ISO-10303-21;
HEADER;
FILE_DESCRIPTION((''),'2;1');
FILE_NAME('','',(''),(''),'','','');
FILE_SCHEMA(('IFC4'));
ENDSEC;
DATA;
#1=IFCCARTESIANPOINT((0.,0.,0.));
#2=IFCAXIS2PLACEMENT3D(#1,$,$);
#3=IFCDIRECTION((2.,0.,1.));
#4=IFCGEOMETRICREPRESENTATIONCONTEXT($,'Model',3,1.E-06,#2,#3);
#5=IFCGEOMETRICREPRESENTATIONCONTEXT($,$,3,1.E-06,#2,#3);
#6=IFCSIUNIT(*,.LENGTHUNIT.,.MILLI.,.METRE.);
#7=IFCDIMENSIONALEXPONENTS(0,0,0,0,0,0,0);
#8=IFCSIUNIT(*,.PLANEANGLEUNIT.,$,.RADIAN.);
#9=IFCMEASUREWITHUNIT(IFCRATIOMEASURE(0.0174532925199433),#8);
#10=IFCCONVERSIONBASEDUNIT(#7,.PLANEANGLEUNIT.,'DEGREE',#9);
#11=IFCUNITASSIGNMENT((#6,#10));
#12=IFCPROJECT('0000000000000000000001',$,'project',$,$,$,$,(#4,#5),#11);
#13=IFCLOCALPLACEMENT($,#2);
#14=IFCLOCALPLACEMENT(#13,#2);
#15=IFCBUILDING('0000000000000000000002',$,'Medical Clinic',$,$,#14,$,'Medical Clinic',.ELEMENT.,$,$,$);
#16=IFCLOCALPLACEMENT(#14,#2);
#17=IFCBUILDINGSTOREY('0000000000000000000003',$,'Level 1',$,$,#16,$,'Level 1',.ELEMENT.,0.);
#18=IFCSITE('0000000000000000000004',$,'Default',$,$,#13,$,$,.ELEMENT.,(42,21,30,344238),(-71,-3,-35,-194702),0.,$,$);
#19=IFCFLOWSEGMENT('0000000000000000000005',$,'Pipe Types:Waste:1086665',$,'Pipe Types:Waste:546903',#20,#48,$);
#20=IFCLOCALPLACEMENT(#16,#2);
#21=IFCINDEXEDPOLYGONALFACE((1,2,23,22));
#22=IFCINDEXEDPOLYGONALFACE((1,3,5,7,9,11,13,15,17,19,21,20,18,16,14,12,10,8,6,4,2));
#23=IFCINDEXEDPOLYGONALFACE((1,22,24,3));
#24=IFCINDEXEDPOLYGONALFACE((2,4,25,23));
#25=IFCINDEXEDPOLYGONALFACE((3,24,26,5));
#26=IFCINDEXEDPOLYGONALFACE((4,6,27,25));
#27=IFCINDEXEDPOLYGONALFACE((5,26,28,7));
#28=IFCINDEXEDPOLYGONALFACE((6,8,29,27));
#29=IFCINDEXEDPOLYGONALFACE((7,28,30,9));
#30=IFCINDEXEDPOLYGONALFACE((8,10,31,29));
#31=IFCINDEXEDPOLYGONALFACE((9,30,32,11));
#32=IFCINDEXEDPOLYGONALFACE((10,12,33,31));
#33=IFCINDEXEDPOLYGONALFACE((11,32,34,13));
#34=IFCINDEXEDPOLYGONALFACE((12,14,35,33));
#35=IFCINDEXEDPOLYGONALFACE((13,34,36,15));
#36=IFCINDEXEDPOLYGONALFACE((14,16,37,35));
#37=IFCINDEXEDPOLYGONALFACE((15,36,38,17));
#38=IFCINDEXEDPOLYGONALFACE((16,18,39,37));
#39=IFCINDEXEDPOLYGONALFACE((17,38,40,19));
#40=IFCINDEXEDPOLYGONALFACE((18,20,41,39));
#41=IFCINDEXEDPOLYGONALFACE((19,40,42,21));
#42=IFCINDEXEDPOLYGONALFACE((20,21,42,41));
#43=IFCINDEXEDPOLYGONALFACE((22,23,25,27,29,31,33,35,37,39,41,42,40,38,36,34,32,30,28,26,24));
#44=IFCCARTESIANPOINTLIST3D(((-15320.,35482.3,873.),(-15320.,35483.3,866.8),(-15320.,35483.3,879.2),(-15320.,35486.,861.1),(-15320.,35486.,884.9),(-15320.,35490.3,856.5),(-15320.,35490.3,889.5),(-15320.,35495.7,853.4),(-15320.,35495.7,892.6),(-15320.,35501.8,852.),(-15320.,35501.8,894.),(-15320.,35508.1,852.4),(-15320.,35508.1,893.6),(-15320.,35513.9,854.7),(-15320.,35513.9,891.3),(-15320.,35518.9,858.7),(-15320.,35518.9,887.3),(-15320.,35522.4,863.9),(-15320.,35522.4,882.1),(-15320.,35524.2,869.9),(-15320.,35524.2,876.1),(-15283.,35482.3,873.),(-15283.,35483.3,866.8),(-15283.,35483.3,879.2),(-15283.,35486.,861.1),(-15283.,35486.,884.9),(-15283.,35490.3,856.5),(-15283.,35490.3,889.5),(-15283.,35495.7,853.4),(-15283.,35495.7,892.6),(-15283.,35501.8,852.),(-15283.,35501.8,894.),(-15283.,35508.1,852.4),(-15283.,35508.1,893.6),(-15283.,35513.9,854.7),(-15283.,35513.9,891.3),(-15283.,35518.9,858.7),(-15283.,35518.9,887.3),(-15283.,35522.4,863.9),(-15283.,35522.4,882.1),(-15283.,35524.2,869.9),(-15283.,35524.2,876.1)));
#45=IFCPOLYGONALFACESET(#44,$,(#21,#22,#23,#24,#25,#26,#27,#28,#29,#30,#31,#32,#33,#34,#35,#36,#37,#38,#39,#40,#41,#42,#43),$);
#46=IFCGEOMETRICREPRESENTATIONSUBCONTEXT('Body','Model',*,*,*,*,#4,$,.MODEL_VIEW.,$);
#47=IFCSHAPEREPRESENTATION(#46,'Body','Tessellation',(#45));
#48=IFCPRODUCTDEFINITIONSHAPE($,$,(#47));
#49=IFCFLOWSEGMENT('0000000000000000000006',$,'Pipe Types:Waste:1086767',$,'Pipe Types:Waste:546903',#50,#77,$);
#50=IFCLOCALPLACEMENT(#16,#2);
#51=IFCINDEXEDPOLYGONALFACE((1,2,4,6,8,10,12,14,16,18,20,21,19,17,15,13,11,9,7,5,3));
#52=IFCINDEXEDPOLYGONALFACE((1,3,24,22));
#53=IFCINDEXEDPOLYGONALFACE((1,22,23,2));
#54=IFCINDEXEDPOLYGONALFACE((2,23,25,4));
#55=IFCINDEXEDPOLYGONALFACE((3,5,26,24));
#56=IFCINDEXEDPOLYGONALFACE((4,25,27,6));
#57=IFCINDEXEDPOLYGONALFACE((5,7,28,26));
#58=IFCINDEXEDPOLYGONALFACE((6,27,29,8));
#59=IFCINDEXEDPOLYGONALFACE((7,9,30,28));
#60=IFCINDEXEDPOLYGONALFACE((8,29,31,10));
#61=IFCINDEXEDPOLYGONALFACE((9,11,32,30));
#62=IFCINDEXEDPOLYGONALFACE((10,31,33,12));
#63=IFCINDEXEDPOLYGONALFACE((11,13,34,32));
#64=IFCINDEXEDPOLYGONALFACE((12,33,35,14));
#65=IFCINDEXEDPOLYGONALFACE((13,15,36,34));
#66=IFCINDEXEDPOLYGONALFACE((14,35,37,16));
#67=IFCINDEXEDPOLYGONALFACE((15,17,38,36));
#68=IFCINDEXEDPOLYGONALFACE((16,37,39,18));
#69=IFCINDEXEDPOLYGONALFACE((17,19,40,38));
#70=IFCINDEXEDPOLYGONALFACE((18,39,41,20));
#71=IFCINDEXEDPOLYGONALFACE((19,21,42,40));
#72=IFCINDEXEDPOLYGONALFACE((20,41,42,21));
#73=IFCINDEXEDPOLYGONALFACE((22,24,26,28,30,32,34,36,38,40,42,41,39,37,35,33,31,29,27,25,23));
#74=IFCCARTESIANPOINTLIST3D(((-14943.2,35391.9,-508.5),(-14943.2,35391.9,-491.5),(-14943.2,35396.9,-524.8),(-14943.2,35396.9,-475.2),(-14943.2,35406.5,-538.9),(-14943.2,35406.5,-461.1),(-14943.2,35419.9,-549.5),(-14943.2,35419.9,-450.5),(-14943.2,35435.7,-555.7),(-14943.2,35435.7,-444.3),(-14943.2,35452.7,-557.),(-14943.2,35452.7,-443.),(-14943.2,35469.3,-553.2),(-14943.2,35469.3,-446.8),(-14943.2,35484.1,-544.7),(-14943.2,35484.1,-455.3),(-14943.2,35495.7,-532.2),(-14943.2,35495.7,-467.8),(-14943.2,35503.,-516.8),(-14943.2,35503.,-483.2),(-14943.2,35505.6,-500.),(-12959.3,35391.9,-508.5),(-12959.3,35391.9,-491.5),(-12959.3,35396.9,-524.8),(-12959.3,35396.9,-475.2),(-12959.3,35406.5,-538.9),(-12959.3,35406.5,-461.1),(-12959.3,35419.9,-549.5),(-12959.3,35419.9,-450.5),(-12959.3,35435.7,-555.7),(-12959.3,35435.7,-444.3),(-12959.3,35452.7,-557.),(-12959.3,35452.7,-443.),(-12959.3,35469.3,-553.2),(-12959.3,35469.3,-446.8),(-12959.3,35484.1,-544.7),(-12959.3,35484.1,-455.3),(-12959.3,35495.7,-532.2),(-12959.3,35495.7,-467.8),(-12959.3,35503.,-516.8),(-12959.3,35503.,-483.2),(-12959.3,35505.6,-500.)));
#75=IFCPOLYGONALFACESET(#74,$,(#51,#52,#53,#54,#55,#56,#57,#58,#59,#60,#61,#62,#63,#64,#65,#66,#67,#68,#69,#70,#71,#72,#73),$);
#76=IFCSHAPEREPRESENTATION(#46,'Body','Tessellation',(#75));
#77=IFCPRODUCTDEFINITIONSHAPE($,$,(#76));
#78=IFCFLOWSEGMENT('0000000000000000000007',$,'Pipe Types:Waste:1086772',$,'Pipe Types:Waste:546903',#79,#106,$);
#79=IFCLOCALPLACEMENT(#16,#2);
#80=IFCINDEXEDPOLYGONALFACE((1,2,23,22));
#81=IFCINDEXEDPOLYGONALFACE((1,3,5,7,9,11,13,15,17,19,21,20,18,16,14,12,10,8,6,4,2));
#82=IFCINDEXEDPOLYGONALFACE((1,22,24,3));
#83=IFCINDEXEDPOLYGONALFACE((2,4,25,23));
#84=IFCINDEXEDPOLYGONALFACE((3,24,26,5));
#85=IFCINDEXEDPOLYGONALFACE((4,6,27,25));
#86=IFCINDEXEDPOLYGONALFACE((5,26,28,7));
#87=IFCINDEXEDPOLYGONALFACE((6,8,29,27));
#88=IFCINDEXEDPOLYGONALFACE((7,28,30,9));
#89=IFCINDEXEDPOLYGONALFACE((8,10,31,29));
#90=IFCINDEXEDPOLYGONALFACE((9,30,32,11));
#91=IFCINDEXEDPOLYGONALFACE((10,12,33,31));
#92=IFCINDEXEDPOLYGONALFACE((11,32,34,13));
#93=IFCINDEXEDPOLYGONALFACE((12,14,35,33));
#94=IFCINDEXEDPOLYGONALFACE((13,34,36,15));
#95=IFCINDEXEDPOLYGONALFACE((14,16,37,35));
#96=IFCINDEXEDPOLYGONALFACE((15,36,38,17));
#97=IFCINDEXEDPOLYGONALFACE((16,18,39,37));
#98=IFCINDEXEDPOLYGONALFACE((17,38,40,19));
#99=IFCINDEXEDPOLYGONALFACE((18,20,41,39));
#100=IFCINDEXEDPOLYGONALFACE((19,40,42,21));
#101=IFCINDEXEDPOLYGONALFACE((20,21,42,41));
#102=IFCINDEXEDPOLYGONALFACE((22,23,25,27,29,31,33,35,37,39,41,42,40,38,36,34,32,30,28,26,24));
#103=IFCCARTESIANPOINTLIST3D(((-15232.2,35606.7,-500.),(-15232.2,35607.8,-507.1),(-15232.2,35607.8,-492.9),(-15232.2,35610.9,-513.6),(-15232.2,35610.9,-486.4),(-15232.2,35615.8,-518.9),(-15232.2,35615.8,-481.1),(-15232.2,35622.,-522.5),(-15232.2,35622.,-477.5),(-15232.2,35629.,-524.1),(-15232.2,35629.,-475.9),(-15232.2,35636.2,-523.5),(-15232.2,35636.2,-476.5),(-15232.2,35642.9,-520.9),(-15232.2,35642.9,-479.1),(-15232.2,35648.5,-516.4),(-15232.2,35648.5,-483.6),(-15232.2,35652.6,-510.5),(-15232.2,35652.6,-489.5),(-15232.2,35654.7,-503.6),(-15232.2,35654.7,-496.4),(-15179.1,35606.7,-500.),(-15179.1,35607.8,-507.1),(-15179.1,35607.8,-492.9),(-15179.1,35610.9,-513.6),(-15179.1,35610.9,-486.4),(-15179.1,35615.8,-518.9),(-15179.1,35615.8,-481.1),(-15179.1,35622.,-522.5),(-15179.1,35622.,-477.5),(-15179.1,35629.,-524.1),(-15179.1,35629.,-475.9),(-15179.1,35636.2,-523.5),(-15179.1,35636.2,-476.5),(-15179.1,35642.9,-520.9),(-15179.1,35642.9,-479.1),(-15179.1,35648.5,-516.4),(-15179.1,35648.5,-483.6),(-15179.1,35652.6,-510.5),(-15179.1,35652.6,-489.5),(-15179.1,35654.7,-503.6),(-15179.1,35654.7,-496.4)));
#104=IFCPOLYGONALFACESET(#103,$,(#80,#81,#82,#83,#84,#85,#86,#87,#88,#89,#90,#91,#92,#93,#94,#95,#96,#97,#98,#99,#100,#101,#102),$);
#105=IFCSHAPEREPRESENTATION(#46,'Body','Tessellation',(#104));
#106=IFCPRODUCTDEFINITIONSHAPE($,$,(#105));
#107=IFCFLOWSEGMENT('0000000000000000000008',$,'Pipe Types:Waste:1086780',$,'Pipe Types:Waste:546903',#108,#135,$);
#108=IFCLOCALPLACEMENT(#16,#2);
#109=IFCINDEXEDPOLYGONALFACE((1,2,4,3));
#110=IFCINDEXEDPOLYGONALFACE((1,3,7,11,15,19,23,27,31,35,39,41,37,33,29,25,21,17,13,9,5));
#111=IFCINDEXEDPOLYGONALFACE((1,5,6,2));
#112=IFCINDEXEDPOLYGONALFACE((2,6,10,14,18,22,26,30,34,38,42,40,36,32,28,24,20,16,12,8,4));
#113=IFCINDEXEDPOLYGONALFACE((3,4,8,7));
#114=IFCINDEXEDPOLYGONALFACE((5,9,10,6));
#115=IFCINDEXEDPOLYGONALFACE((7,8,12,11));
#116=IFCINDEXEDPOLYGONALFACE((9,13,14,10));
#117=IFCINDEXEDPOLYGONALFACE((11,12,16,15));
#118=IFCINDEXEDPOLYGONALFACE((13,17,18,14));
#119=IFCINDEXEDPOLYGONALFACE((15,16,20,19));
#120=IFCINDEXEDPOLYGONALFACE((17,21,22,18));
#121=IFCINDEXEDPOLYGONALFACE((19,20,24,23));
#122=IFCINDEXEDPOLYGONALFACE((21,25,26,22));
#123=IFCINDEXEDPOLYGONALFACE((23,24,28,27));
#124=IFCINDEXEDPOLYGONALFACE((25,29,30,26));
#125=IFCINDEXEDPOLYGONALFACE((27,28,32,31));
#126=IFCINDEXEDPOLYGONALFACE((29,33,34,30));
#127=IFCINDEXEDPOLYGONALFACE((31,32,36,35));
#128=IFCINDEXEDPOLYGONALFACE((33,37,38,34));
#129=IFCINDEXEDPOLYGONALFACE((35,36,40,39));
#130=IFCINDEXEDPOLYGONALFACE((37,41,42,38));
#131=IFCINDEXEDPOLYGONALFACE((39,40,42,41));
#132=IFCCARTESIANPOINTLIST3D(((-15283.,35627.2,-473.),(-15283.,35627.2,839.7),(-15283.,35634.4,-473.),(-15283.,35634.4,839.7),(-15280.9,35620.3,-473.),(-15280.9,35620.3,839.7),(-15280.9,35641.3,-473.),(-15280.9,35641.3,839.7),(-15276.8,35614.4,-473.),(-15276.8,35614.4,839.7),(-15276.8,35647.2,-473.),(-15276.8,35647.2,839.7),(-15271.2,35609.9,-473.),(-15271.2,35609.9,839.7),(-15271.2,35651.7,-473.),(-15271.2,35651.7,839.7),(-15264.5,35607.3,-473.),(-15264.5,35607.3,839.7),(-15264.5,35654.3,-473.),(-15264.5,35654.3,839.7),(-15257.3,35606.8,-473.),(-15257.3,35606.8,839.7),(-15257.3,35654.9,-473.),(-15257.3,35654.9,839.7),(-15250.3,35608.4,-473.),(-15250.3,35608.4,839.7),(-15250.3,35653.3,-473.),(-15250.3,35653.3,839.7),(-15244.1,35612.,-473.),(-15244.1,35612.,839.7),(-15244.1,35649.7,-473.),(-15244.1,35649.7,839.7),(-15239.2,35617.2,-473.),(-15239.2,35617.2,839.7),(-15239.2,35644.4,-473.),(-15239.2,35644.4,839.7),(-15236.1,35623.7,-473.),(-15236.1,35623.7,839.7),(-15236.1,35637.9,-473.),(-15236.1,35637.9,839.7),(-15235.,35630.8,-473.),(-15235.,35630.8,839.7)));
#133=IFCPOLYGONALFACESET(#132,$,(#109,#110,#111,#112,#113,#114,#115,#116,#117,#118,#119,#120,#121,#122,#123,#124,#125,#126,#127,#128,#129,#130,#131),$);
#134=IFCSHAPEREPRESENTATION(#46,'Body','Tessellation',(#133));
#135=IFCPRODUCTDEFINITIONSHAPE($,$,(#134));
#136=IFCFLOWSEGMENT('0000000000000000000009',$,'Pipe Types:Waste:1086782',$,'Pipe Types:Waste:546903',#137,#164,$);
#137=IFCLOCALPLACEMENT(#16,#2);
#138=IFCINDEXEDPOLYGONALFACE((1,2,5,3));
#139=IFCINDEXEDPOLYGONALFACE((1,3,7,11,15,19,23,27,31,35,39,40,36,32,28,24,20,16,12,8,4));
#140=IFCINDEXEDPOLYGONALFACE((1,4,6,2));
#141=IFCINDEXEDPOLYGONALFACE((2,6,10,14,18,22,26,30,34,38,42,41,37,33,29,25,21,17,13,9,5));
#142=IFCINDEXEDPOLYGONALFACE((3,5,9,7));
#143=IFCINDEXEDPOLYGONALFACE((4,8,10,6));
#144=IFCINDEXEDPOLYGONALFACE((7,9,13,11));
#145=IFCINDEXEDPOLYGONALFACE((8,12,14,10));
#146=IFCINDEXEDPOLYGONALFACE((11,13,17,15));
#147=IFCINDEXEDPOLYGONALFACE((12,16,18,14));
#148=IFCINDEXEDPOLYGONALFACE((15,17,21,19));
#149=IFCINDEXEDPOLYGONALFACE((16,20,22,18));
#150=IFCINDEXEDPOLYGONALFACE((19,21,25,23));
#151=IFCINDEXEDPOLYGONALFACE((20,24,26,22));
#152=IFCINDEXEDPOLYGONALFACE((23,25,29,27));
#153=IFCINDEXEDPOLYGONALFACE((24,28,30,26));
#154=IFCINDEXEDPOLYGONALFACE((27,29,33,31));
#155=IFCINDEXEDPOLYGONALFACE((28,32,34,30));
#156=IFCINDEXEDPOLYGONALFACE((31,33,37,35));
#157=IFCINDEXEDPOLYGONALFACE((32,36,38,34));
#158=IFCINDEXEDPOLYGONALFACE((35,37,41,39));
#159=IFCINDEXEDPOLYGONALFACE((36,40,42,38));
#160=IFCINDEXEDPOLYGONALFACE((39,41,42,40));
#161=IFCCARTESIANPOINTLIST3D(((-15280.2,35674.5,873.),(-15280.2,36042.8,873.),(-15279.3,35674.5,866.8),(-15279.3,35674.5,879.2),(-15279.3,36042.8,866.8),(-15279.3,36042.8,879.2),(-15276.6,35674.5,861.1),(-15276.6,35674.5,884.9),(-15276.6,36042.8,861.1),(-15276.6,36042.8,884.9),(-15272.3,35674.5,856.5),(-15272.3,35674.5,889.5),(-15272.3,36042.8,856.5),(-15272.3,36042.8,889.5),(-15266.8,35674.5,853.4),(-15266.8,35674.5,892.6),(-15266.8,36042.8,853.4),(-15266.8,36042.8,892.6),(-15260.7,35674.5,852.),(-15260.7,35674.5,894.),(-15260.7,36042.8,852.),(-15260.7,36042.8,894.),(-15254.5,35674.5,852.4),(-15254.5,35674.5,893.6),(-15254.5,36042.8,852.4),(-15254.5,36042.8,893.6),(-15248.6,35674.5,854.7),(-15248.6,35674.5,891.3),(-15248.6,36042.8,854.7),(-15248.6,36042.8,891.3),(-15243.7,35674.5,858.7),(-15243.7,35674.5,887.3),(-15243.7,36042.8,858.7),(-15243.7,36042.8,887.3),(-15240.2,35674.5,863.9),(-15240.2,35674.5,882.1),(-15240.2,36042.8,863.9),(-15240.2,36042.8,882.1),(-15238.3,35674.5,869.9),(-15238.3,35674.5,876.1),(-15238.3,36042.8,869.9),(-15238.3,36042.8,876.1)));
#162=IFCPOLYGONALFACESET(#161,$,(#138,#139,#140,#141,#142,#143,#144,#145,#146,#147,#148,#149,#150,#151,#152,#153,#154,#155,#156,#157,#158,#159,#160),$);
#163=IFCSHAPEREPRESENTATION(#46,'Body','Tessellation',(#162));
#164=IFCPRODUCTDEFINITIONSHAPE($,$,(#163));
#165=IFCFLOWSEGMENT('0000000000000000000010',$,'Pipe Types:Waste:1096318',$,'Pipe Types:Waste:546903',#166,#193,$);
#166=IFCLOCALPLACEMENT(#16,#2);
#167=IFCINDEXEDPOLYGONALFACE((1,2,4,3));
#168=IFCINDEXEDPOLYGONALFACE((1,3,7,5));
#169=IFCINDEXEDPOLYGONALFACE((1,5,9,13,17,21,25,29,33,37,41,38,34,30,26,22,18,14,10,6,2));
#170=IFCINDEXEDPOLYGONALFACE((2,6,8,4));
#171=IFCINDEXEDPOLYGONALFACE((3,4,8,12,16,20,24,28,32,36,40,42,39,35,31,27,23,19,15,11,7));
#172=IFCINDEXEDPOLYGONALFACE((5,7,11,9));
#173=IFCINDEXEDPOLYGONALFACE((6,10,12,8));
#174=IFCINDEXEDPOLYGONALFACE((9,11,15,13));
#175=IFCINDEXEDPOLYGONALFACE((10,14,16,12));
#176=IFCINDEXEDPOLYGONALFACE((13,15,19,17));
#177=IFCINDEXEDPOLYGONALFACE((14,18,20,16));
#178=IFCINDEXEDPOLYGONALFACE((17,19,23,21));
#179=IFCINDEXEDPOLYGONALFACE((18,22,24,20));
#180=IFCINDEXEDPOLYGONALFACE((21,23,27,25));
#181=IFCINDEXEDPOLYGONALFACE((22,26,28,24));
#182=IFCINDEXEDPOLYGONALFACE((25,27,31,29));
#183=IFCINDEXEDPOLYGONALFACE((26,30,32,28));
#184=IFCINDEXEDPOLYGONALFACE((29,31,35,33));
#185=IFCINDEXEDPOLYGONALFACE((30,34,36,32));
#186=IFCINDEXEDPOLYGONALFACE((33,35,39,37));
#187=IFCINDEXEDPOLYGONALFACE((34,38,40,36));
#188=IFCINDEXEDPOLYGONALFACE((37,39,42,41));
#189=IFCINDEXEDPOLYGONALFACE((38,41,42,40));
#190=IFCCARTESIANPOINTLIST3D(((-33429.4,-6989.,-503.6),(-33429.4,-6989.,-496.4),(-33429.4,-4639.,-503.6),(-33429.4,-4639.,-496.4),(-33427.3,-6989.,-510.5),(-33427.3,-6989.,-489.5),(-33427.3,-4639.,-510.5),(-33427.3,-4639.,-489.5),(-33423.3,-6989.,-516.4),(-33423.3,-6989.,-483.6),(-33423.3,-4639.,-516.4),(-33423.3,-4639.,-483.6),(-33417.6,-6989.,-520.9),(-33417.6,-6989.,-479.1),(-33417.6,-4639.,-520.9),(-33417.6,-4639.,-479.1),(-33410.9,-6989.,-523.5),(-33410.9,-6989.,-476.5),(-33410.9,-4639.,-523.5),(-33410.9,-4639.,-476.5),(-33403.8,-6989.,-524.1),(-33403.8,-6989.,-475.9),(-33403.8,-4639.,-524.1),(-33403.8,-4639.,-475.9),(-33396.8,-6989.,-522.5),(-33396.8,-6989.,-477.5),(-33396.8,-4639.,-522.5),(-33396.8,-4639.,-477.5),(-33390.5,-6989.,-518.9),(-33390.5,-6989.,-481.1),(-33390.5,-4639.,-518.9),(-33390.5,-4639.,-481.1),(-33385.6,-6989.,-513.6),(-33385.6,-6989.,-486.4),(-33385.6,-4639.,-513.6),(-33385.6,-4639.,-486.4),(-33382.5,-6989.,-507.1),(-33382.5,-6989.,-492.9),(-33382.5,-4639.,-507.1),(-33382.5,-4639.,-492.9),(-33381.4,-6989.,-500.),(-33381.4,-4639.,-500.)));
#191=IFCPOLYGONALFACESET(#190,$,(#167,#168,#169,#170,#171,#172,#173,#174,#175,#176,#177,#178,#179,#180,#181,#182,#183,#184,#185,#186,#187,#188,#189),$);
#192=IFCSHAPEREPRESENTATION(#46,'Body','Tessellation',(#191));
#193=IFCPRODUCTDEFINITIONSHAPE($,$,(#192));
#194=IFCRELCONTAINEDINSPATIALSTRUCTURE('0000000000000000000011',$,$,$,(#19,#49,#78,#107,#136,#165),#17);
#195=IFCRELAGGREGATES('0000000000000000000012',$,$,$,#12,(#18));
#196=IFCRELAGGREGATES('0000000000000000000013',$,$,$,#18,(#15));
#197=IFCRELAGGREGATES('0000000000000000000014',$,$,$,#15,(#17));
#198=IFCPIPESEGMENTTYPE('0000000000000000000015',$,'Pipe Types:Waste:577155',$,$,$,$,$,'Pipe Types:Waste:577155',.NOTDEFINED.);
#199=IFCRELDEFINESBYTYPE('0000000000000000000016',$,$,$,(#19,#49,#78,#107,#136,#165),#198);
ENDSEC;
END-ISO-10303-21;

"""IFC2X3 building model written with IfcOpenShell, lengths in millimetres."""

from ifc_helpers import new_model, entity, si_unit, converted_unit, direction, frame, frame_2d, origin, origin_2d_with_axis, place, context, subcontext, project, spatial, circle, extrude, type_object, element, save


model = new_model("IFC2X3")

# Units and contexts
model_context = context("Model", 3, precision=1e-06, world=origin(), true_north=direction((2.0, 0.0, 1.0)))
context_of_model = context(None, 3, precision=1e-06, world=origin(), true_north=direction((2.0, 0.0, 1.0)))
body_context = subcontext(model_context, "Body", "Model", "MODEL_VIEW")
ifc_project = project(units=[si_unit("LENGTHUNIT", "METRE", prefix="MILLI"), converted_unit("PLANEANGLEUNIT", "DEGREE", entity("IfcRatioMeasure", 0.0174532925199433), si_unit("PLANEANGLEUNIT", "RADIAN"), dimensions=[0, 0, 0, 0, 0, 0, 0])], contexts=[model_context, context_of_model])

# Site, building, storey
site_placement = place(None, origin())
site = spatial("IfcSite", under=ifc_project, at=site_placement, Name="Default", CompositionType="ELEMENT", RefLatitude=(42, 21, 30, 344238), RefLongitude=(-71, -3, -35, -194702), RefElevation=0.0)
building_placement = place(site_placement, origin())
building = spatial("IfcBuilding", under=site, at=building_placement, Name="Medical Clinic", LongName="Medical Clinic", CompositionType="ELEMENT")
storey_placement = place(building_placement, origin())
storey = spatial("IfcBuildingStorey", under=building, at=storey_placement, Name="Level 1", LongName="Level 1", CompositionType="ELEMENT", Elevation=0.0)

# Flow segments
pipe_segment_type_1 = type_object("IfcPipeSegmentType", Name="Pipe Types:Waste:577155", ElementType="Pipe Types:Waste:577155", PredefinedType="NOTDEFINED")
flow_segment_1_placement = place(storey_placement, origin())
element("IfcFlowSegment", 1, at=flow_segment_1_placement, inside=storey, type_object=pipe_segment_type_1, Name="Pipe Types:Waste:1086665", ObjectType="Pipe Types:Waste:546903", context=body_context, shape_type="SweptSolid", body=[
    extrude(circle(Radius=21.1, at=origin_2d_with_axis()), frame((-15320.0, 35503.4, 873.0), z_axis=(1.0, 0.0, 0.0), x_axis=(0.0, -1.0, 0.0)), (0.0, 0.0, 1.0), 37.0),
])
flow_segment_2_placement = place(storey_placement, origin())
element("IfcFlowSegment", 2, at=flow_segment_2_placement, inside=storey, type_object=pipe_segment_type_1, Name="Pipe Types:Waste:1086767", ObjectType="Pipe Types:Waste:546903", context=body_context, shape_type="SweptSolid", body=[
    extrude(circle(Radius=57.1, at=frame_2d((0.0, 0.0), x_axis=(1.0, 0.0))), frame((-14943.2, 35448.4, -500.0), z_axis=(1.0, 0.0, 0.0), x_axis=(0.0, 1.0, 0.0)), (0.0, 0.0, 1.0), 1983.8),
])
flow_segment_3_placement = place(storey_placement, origin())
element("IfcFlowSegment", 3, at=flow_segment_3_placement, inside=storey, type_object=pipe_segment_type_1, Name="Pipe Types:Waste:1086772", ObjectType="Pipe Types:Waste:546903", context=body_context, shape_type="SweptSolid", body=[
    extrude(circle(Radius=24.1, at=origin_2d_with_axis()), frame((-15232.2, 35630.8, -500.0), z_axis=(1.0, 0.0, 0.0), x_axis=(0.0, -1.0, 0.0)), (0.0, 0.0, 1.0), 53.1),
])
flow_segment_4_placement = place(storey_placement, origin())
element("IfcFlowSegment", 4, at=flow_segment_4_placement, inside=storey, type_object=pipe_segment_type_1, Name="Pipe Types:Waste:1086780", ObjectType="Pipe Types:Waste:546903", context=body_context, shape_type="SweptSolid", body=[
    extrude(circle(Radius=24.1, at=frame_2d((0.0, 0.0), x_axis=(1.0, 0.0))), frame((-15259.1, 35630.8, -473.0)), (0.0, 0.0, 1.0), 1312.7),
])
flow_segment_5_placement = place(storey_placement, origin())
element("IfcFlowSegment", 5, at=flow_segment_5_placement, inside=storey, type_object=pipe_segment_type_1, Name="Pipe Types:Waste:1086782", ObjectType="Pipe Types:Waste:546903", context=body_context, shape_type="SweptSolid", body=[
    extrude(circle(Radius=21.1, at=frame_2d((0.0, 0.0), x_axis=(1.0, 0.0))), frame((-15259.1, 35674.5, 873.0), z_axis=(0.0, 1.0, 0.0), x_axis=(-1.0, 0.0, 0.0)), (0.0, 0.0, 1.0), 368.3),
])
flow_segment_6_placement = place(storey_placement, origin())
element("IfcFlowSegment", 6, at=flow_segment_6_placement, inside=storey, type_object=pipe_segment_type_1, Name="Pipe Types:Waste:1096318", ObjectType="Pipe Types:Waste:546903", context=body_context, shape_type="SweptSolid", body=[
    extrude(circle(Radius=24.1, at=origin_2d_with_axis()), frame((-33405.6, -6989.0, -500.0), z_axis=(0.0, 1.0, 0.0), x_axis=(1.0, 0.0, 0.0)), (0.0, 0.0, 1.0), 2350.0),
])

save(model, "model.ifc")
